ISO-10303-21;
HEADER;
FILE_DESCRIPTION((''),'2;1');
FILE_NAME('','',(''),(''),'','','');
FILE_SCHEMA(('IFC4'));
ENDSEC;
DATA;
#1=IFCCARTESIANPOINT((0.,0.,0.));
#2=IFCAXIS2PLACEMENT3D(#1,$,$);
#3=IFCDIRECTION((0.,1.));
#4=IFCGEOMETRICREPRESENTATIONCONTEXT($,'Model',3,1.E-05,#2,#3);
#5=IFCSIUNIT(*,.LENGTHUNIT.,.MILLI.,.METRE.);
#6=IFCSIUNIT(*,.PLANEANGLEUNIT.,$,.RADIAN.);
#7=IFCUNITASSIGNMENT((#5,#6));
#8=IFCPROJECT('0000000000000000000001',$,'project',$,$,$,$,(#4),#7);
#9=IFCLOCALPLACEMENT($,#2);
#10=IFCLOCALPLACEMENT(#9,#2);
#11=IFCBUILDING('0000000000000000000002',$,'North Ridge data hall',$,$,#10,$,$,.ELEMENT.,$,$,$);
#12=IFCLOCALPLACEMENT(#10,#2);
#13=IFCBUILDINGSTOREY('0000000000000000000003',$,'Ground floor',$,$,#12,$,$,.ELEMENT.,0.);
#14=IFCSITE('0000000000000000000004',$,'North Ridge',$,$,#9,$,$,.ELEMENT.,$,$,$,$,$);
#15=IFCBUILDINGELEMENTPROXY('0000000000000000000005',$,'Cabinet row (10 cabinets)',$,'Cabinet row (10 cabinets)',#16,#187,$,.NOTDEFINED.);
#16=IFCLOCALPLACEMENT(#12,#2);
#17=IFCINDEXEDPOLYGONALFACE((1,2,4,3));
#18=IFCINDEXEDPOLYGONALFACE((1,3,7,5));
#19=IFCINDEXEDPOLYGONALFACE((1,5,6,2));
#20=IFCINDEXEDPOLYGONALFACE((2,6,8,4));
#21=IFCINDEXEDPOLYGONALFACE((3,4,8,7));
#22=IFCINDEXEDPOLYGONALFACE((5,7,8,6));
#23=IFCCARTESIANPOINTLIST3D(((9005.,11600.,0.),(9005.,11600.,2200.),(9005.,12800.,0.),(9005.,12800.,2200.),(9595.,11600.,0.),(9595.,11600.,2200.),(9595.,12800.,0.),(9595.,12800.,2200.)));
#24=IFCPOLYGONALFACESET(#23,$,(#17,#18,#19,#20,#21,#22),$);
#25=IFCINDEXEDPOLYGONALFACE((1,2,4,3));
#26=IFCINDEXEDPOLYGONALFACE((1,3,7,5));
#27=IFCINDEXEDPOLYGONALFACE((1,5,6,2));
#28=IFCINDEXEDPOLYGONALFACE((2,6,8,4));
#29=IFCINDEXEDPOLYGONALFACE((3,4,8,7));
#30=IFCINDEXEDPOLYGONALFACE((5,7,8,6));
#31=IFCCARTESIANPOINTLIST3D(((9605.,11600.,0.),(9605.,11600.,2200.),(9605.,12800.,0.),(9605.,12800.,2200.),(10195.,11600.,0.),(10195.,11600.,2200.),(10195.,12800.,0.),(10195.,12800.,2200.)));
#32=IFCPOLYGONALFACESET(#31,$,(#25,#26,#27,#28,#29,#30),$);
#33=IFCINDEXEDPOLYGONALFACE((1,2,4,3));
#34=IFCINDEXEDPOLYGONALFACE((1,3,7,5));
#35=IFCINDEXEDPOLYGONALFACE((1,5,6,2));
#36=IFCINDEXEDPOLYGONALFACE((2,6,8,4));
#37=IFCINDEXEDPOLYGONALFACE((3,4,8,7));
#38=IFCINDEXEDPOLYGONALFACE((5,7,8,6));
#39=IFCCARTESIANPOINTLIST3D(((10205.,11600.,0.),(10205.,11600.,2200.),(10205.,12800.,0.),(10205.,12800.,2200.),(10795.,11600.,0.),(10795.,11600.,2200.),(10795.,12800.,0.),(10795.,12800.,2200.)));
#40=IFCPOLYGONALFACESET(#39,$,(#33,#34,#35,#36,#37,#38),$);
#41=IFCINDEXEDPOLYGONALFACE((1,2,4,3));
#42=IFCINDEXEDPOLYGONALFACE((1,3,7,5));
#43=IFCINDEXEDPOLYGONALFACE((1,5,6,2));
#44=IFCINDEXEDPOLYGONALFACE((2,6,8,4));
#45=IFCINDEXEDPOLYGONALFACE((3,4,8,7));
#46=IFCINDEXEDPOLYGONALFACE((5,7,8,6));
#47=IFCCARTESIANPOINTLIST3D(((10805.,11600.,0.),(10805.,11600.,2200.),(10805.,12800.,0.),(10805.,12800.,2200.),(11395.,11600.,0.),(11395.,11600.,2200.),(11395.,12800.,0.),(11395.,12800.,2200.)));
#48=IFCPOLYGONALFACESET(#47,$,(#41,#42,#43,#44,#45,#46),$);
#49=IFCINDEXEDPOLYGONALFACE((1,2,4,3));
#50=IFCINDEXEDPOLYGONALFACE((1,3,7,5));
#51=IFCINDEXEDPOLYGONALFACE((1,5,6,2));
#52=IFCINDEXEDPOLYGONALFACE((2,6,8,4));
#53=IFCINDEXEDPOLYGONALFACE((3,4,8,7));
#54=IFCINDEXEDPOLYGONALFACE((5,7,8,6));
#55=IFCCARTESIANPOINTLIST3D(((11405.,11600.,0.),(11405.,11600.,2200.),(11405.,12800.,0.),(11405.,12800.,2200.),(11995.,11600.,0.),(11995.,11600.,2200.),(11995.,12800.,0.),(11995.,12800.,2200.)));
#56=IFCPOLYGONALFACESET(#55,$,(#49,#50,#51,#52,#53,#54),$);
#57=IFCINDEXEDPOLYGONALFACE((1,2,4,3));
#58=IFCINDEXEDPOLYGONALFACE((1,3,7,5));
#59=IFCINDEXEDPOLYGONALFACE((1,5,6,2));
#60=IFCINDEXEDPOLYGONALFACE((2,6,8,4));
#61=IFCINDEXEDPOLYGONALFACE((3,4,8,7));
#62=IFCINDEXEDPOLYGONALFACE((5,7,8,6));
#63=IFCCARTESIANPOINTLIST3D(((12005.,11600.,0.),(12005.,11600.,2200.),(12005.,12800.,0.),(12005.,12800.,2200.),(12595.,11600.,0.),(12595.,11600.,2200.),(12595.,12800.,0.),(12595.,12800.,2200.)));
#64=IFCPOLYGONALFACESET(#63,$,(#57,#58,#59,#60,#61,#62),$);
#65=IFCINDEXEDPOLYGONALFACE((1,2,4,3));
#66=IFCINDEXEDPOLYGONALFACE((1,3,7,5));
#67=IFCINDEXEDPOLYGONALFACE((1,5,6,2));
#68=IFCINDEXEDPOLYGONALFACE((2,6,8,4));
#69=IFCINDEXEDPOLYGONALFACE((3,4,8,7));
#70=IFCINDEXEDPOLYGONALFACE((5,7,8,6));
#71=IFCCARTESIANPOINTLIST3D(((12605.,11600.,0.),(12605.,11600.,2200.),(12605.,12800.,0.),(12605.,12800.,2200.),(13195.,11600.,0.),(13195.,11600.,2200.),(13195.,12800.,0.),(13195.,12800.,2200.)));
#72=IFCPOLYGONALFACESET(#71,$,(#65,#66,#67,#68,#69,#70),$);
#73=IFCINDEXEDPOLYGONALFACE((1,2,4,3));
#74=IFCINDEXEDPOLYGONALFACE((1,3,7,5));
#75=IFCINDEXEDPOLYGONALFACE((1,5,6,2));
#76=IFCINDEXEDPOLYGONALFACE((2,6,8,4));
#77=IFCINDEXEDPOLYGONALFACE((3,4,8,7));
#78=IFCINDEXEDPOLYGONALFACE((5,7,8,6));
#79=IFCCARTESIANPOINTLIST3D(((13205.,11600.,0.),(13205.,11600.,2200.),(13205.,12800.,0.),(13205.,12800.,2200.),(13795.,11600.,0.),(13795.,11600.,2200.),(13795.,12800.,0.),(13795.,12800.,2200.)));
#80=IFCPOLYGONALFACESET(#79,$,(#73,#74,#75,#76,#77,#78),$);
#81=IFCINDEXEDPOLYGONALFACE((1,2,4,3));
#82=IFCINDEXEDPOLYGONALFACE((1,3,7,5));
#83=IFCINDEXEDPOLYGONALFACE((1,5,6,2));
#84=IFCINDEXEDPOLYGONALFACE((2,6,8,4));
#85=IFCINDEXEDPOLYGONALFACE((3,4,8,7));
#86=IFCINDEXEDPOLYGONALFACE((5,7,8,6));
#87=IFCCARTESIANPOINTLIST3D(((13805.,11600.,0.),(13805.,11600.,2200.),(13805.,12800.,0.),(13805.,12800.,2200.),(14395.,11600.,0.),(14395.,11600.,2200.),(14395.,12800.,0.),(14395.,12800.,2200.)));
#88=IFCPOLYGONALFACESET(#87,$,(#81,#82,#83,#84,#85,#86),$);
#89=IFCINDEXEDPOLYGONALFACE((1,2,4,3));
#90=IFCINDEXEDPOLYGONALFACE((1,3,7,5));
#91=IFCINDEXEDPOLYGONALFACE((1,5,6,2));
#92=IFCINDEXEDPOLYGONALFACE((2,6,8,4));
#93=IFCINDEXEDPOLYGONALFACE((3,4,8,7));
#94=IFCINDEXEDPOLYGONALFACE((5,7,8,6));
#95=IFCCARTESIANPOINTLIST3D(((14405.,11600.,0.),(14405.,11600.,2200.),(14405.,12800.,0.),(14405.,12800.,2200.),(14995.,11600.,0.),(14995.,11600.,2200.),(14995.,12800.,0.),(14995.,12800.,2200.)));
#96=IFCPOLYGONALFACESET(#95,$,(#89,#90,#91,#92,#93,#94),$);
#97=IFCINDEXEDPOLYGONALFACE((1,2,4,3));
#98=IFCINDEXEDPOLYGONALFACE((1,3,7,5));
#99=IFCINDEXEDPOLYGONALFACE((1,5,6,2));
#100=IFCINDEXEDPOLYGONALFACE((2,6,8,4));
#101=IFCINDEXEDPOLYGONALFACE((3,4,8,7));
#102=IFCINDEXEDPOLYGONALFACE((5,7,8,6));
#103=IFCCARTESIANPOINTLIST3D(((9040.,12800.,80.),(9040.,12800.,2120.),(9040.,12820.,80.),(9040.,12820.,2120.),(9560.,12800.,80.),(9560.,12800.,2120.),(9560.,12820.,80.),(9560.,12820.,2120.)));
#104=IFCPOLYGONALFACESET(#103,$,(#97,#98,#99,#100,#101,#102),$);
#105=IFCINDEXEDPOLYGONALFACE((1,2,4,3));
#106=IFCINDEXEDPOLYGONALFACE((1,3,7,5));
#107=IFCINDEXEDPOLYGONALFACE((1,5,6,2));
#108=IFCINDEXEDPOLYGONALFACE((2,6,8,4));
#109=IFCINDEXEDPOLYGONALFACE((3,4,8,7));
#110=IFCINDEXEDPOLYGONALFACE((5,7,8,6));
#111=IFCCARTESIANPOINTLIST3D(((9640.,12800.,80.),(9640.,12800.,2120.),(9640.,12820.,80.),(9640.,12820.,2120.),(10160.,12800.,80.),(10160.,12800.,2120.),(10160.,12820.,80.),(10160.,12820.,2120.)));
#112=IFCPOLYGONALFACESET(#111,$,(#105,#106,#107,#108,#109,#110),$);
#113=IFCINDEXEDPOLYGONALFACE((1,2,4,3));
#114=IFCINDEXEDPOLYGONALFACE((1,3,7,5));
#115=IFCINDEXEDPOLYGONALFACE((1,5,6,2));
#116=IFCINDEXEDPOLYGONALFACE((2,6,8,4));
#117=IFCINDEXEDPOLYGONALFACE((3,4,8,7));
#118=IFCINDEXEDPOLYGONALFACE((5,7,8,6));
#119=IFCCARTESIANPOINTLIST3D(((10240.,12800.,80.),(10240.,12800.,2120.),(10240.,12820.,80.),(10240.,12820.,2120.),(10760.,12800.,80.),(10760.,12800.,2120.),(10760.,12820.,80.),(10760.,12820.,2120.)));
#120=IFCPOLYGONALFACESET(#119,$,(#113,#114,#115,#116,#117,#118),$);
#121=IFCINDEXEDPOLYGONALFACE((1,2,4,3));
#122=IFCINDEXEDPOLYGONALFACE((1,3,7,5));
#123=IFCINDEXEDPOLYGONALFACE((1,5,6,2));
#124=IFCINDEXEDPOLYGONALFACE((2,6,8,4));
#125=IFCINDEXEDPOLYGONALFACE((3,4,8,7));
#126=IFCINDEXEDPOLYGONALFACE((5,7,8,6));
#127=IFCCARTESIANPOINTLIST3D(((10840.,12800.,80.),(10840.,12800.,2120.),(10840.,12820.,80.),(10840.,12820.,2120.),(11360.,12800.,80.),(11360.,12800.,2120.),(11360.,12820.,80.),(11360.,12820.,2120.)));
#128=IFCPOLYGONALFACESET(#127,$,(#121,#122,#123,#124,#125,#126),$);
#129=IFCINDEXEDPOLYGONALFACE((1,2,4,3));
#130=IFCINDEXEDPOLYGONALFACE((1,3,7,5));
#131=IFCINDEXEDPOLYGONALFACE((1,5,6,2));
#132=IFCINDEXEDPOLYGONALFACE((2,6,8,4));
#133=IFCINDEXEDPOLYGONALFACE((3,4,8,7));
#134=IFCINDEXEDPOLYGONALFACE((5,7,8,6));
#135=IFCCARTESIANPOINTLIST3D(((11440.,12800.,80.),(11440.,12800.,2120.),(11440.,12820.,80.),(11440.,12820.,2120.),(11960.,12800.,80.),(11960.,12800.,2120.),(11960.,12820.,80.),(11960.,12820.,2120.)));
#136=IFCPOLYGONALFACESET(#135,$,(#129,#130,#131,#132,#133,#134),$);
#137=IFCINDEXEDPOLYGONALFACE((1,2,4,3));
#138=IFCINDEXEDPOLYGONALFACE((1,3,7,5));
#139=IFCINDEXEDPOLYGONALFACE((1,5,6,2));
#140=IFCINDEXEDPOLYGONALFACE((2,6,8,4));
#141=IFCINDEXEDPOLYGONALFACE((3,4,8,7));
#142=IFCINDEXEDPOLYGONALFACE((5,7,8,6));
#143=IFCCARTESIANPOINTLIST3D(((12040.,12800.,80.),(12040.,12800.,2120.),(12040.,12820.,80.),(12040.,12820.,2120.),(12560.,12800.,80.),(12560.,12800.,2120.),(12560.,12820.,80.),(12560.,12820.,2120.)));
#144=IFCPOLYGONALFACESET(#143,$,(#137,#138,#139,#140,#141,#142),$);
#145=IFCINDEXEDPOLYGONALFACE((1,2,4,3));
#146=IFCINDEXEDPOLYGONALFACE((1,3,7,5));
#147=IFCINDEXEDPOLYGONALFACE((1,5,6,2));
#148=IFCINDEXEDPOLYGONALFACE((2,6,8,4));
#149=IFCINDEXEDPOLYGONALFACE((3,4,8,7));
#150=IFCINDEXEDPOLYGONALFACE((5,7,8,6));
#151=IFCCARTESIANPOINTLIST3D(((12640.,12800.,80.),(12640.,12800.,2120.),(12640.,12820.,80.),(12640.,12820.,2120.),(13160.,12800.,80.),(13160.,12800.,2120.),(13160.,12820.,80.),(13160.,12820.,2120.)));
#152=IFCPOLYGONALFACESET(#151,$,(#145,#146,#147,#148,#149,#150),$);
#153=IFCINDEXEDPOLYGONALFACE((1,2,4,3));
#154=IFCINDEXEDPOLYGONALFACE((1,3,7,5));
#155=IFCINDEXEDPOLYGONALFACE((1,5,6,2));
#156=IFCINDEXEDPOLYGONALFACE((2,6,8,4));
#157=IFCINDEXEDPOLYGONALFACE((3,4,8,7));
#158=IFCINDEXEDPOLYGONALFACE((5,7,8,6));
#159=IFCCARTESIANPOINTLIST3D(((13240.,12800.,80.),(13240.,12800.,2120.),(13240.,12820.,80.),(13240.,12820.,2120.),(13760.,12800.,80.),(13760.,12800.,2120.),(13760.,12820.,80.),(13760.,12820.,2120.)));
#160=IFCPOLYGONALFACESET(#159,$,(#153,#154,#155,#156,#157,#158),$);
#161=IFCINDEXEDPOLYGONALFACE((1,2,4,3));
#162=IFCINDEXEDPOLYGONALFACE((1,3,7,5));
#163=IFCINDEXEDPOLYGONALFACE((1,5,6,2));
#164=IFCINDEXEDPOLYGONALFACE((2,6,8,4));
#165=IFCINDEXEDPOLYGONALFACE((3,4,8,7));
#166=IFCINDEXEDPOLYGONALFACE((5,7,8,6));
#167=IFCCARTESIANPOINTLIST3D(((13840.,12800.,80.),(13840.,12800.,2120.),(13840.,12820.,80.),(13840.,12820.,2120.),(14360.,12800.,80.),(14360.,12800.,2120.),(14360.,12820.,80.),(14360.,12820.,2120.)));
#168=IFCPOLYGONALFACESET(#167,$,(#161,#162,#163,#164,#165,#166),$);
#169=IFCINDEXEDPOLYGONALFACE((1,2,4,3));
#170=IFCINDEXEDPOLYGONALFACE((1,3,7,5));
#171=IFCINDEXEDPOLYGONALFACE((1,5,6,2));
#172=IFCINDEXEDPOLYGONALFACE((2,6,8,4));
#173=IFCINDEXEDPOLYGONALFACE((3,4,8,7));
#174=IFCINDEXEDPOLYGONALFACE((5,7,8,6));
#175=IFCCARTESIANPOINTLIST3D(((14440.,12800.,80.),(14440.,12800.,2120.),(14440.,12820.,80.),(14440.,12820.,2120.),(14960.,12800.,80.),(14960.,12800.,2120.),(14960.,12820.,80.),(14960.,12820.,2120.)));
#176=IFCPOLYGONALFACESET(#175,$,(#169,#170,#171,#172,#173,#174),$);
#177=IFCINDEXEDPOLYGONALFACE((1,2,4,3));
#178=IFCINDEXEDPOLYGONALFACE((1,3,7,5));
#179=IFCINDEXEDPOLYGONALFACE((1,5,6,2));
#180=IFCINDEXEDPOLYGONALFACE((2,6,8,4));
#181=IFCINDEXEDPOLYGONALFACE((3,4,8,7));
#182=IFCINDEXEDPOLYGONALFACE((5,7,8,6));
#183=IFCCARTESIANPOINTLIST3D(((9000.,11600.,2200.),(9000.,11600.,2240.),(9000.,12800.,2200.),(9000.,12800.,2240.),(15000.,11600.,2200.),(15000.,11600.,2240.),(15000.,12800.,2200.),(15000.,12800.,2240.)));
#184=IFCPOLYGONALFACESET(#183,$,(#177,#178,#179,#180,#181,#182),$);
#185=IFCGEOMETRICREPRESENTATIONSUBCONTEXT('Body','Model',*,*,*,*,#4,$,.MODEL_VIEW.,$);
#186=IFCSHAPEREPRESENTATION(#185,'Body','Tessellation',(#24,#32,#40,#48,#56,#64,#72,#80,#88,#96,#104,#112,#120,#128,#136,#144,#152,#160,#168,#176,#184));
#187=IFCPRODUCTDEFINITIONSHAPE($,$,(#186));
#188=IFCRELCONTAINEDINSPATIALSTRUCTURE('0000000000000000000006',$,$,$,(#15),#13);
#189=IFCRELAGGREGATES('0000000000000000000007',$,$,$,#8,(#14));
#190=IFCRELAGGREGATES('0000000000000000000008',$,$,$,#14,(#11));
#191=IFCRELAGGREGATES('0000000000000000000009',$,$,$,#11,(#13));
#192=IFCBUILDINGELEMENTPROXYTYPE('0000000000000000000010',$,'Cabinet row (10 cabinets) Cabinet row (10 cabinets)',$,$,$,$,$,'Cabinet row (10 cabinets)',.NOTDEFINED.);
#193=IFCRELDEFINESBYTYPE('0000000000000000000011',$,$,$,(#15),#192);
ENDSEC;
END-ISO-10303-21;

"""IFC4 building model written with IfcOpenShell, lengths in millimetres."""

from ifc_helpers import new_model, si_unit, direction, frame, origin, place, context, subcontext, project, spatial, polyline, outline, extrude, source, transform, mapped, type_object, type_shapes, element, save


model = new_model("IFC4")

# Units and contexts
model_context = context("Model", 3, precision=1e-05, world=origin(), true_north=direction((0.0, 1.0)))
body_context = subcontext(model_context, "Body", "Model", "MODEL_VIEW")
ifc_project = project(units=[si_unit("LENGTHUNIT", "METRE", prefix="MILLI"), si_unit("PLANEANGLEUNIT", "RADIAN")], contexts=[model_context])

# Site, building, storey
site_placement = place(None, origin())
site = spatial("IfcSite", under=ifc_project, at=site_placement, Name="North Ridge", CompositionType="ELEMENT")
building_placement = place(site_placement, origin())
building = spatial("IfcBuilding", under=site, at=building_placement, Name="North Ridge data hall", CompositionType="ELEMENT")
storey_placement = place(building_placement, origin())
storey = spatial("IfcBuildingStorey", under=building, at=storey_placement, Name="Ground floor", CompositionType="ELEMENT", Elevation=0.0)

# Building element proxy
building_element_proxy_type_1 = type_object("IfcBuildingElementProxyType", Name="Cabinet row (10 cabinets) Cabinet row (10 cabinets)", ElementType="Cabinet row (10 cabinets)", PredefinedType="NOTDEFINED")
shared_shape_1 = source(origin(), body_context, "Body", "SweptSolid", [
    extrude(outline(polyline([(5.0, 0.0), (595.0, 0.0), (595.0, 1200.0), (5.0, 1200.0), (5.0, 0.0)])), origin(), (0.0, 0.0, 1.0), 2200.0),
    extrude(outline(polyline([(605.0, 0.0), (1195.0, 0.0), (1195.0, 1200.0), (605.0, 1200.0), (605.0, 0.0)])), origin(), (0.0, 0.0, 1.0), 2200.0),
    extrude(outline(polyline([(1205.0, 0.0), (1795.0, 0.0), (1795.0, 1200.0), (1205.0, 1200.0), (1205.0, 0.0)])), origin(), (0.0, 0.0, 1.0), 2200.0),
    extrude(outline(polyline([(1805.0, 0.0), (2395.0, 0.0), (2395.0, 1200.0), (1805.0, 1200.0), (1805.0, 0.0)])), origin(), (0.0, 0.0, 1.0), 2200.0),
    extrude(outline(polyline([(2405.0, 0.0), (2995.0, 0.0), (2995.0, 1200.0), (2405.0, 1200.0), (2405.0, 0.0)])), origin(), (0.0, 0.0, 1.0), 2200.0),
    extrude(outline(polyline([(3005.0, 0.0), (3595.0, 0.0), (3595.0, 1200.0), (3005.0, 1200.0), (3005.0, 0.0)])), origin(), (0.0, 0.0, 1.0), 2200.0),
    extrude(outline(polyline([(3605.0, 0.0), (4195.0, 0.0), (4195.0, 1200.0), (3605.0, 1200.0), (3605.0, 0.0)])), origin(), (0.0, 0.0, 1.0), 2200.0),
    extrude(outline(polyline([(4205.0, 0.0), (4795.0, 0.0), (4795.0, 1200.0), (4205.0, 1200.0), (4205.0, 0.0)])), origin(), (0.0, 0.0, 1.0), 2200.0),
    extrude(outline(polyline([(4805.0, 0.0), (5395.0, 0.0), (5395.0, 1200.0), (4805.0, 1200.0), (4805.0, 0.0)])), origin(), (0.0, 0.0, 1.0), 2200.0),
    extrude(outline(polyline([(5405.0, 0.0), (5995.0, 0.0), (5995.0, 1200.0), (5405.0, 1200.0), (5405.0, 0.0)])), origin(), (0.0, 0.0, 1.0), 2200.0),
    extrude(outline(polyline([(40.0, 1200.0), (560.0, 1200.0), (560.0, 1220.0), (40.0, 1220.0), (40.0, 1200.0)])), frame((0.0, 0.0, 80.0)), (0.0, 0.0, 1.0), 2040.0),
    extrude(outline(polyline([(640.0, 1200.0), (1160.0, 1200.0), (1160.0, 1220.0), (640.0, 1220.0), (640.0, 1200.0)])), frame((0.0, 0.0, 80.0)), (0.0, 0.0, 1.0), 2040.0),
    extrude(outline(polyline([(1240.0, 1200.0), (1760.0, 1200.0), (1760.0, 1220.0), (1240.0, 1220.0), (1240.0, 1200.0)])), frame((0.0, 0.0, 80.0)), (0.0, 0.0, 1.0), 2040.0),
    extrude(outline(polyline([(1840.0, 1200.0), (2360.0, 1200.0), (2360.0, 1220.0), (1840.0, 1220.0), (1840.0, 1200.0)])), frame((0.0, 0.0, 80.0)), (0.0, 0.0, 1.0), 2040.0),
    extrude(outline(polyline([(2440.0, 1200.0), (2960.0, 1200.0), (2960.0, 1220.0), (2440.0, 1220.0), (2440.0, 1200.0)])), frame((0.0, 0.0, 80.0)), (0.0, 0.0, 1.0), 2040.0),
    extrude(outline(polyline([(3040.0, 1200.0), (3560.0, 1200.0), (3560.0, 1220.0), (3040.0, 1220.0), (3040.0, 1200.0)])), frame((0.0, 0.0, 80.0)), (0.0, 0.0, 1.0), 2040.0),
    extrude(outline(polyline([(3640.0, 1200.0), (4160.0, 1200.0), (4160.0, 1220.0), (3640.0, 1220.0), (3640.0, 1200.0)])), frame((0.0, 0.0, 80.0)), (0.0, 0.0, 1.0), 2040.0),
    extrude(outline(polyline([(4240.0, 1200.0), (4760.0, 1200.0), (4760.0, 1220.0), (4240.0, 1220.0), (4240.0, 1200.0)])), frame((0.0, 0.0, 80.0)), (0.0, 0.0, 1.0), 2040.0),
    extrude(outline(polyline([(4840.0, 1200.0), (5360.0, 1200.0), (5360.0, 1220.0), (4840.0, 1220.0), (4840.0, 1200.0)])), frame((0.0, 0.0, 80.0)), (0.0, 0.0, 1.0), 2040.0),
    extrude(outline(polyline([(5440.0, 1200.0), (5960.0, 1200.0), (5960.0, 1220.0), (5440.0, 1220.0), (5440.0, 1200.0)])), frame((0.0, 0.0, 80.0)), (0.0, 0.0, 1.0), 2040.0),
    extrude(outline(polyline([(0.0, 0.0), (6000.0, 0.0), (6000.0, 1200.0), (0.0, 1200.0), (0.0, 0.0)])), frame((0.0, 0.0, 2200.0)), (0.0, 0.0, 1.0), 40.0),
])
type_shapes(building_element_proxy_type_1, [shared_shape_1])
for number, where, z_axis, x_axis, name in (
    (1, (9000.0, 11600.0, 0.0), (0.0, 0.0, 1.0), (1.0, 0.0, 0.0), "Cabinet row (10 cabinets)"),
):
    element("IfcBuildingElementProxy", number, at=place(storey_placement, frame(where, z_axis=z_axis, x_axis=x_axis)), inside=storey, type_object=building_element_proxy_type_1, Name=name, ObjectType="Cabinet row (10 cabinets)", PredefinedType="NOTDEFINED", context=body_context, shape_type="MappedRepresentation", body=[
        mapped(shared_shape_1, transform((0.0, 0.0, 0.0))),
    ])

save(model, "model.ifc")
